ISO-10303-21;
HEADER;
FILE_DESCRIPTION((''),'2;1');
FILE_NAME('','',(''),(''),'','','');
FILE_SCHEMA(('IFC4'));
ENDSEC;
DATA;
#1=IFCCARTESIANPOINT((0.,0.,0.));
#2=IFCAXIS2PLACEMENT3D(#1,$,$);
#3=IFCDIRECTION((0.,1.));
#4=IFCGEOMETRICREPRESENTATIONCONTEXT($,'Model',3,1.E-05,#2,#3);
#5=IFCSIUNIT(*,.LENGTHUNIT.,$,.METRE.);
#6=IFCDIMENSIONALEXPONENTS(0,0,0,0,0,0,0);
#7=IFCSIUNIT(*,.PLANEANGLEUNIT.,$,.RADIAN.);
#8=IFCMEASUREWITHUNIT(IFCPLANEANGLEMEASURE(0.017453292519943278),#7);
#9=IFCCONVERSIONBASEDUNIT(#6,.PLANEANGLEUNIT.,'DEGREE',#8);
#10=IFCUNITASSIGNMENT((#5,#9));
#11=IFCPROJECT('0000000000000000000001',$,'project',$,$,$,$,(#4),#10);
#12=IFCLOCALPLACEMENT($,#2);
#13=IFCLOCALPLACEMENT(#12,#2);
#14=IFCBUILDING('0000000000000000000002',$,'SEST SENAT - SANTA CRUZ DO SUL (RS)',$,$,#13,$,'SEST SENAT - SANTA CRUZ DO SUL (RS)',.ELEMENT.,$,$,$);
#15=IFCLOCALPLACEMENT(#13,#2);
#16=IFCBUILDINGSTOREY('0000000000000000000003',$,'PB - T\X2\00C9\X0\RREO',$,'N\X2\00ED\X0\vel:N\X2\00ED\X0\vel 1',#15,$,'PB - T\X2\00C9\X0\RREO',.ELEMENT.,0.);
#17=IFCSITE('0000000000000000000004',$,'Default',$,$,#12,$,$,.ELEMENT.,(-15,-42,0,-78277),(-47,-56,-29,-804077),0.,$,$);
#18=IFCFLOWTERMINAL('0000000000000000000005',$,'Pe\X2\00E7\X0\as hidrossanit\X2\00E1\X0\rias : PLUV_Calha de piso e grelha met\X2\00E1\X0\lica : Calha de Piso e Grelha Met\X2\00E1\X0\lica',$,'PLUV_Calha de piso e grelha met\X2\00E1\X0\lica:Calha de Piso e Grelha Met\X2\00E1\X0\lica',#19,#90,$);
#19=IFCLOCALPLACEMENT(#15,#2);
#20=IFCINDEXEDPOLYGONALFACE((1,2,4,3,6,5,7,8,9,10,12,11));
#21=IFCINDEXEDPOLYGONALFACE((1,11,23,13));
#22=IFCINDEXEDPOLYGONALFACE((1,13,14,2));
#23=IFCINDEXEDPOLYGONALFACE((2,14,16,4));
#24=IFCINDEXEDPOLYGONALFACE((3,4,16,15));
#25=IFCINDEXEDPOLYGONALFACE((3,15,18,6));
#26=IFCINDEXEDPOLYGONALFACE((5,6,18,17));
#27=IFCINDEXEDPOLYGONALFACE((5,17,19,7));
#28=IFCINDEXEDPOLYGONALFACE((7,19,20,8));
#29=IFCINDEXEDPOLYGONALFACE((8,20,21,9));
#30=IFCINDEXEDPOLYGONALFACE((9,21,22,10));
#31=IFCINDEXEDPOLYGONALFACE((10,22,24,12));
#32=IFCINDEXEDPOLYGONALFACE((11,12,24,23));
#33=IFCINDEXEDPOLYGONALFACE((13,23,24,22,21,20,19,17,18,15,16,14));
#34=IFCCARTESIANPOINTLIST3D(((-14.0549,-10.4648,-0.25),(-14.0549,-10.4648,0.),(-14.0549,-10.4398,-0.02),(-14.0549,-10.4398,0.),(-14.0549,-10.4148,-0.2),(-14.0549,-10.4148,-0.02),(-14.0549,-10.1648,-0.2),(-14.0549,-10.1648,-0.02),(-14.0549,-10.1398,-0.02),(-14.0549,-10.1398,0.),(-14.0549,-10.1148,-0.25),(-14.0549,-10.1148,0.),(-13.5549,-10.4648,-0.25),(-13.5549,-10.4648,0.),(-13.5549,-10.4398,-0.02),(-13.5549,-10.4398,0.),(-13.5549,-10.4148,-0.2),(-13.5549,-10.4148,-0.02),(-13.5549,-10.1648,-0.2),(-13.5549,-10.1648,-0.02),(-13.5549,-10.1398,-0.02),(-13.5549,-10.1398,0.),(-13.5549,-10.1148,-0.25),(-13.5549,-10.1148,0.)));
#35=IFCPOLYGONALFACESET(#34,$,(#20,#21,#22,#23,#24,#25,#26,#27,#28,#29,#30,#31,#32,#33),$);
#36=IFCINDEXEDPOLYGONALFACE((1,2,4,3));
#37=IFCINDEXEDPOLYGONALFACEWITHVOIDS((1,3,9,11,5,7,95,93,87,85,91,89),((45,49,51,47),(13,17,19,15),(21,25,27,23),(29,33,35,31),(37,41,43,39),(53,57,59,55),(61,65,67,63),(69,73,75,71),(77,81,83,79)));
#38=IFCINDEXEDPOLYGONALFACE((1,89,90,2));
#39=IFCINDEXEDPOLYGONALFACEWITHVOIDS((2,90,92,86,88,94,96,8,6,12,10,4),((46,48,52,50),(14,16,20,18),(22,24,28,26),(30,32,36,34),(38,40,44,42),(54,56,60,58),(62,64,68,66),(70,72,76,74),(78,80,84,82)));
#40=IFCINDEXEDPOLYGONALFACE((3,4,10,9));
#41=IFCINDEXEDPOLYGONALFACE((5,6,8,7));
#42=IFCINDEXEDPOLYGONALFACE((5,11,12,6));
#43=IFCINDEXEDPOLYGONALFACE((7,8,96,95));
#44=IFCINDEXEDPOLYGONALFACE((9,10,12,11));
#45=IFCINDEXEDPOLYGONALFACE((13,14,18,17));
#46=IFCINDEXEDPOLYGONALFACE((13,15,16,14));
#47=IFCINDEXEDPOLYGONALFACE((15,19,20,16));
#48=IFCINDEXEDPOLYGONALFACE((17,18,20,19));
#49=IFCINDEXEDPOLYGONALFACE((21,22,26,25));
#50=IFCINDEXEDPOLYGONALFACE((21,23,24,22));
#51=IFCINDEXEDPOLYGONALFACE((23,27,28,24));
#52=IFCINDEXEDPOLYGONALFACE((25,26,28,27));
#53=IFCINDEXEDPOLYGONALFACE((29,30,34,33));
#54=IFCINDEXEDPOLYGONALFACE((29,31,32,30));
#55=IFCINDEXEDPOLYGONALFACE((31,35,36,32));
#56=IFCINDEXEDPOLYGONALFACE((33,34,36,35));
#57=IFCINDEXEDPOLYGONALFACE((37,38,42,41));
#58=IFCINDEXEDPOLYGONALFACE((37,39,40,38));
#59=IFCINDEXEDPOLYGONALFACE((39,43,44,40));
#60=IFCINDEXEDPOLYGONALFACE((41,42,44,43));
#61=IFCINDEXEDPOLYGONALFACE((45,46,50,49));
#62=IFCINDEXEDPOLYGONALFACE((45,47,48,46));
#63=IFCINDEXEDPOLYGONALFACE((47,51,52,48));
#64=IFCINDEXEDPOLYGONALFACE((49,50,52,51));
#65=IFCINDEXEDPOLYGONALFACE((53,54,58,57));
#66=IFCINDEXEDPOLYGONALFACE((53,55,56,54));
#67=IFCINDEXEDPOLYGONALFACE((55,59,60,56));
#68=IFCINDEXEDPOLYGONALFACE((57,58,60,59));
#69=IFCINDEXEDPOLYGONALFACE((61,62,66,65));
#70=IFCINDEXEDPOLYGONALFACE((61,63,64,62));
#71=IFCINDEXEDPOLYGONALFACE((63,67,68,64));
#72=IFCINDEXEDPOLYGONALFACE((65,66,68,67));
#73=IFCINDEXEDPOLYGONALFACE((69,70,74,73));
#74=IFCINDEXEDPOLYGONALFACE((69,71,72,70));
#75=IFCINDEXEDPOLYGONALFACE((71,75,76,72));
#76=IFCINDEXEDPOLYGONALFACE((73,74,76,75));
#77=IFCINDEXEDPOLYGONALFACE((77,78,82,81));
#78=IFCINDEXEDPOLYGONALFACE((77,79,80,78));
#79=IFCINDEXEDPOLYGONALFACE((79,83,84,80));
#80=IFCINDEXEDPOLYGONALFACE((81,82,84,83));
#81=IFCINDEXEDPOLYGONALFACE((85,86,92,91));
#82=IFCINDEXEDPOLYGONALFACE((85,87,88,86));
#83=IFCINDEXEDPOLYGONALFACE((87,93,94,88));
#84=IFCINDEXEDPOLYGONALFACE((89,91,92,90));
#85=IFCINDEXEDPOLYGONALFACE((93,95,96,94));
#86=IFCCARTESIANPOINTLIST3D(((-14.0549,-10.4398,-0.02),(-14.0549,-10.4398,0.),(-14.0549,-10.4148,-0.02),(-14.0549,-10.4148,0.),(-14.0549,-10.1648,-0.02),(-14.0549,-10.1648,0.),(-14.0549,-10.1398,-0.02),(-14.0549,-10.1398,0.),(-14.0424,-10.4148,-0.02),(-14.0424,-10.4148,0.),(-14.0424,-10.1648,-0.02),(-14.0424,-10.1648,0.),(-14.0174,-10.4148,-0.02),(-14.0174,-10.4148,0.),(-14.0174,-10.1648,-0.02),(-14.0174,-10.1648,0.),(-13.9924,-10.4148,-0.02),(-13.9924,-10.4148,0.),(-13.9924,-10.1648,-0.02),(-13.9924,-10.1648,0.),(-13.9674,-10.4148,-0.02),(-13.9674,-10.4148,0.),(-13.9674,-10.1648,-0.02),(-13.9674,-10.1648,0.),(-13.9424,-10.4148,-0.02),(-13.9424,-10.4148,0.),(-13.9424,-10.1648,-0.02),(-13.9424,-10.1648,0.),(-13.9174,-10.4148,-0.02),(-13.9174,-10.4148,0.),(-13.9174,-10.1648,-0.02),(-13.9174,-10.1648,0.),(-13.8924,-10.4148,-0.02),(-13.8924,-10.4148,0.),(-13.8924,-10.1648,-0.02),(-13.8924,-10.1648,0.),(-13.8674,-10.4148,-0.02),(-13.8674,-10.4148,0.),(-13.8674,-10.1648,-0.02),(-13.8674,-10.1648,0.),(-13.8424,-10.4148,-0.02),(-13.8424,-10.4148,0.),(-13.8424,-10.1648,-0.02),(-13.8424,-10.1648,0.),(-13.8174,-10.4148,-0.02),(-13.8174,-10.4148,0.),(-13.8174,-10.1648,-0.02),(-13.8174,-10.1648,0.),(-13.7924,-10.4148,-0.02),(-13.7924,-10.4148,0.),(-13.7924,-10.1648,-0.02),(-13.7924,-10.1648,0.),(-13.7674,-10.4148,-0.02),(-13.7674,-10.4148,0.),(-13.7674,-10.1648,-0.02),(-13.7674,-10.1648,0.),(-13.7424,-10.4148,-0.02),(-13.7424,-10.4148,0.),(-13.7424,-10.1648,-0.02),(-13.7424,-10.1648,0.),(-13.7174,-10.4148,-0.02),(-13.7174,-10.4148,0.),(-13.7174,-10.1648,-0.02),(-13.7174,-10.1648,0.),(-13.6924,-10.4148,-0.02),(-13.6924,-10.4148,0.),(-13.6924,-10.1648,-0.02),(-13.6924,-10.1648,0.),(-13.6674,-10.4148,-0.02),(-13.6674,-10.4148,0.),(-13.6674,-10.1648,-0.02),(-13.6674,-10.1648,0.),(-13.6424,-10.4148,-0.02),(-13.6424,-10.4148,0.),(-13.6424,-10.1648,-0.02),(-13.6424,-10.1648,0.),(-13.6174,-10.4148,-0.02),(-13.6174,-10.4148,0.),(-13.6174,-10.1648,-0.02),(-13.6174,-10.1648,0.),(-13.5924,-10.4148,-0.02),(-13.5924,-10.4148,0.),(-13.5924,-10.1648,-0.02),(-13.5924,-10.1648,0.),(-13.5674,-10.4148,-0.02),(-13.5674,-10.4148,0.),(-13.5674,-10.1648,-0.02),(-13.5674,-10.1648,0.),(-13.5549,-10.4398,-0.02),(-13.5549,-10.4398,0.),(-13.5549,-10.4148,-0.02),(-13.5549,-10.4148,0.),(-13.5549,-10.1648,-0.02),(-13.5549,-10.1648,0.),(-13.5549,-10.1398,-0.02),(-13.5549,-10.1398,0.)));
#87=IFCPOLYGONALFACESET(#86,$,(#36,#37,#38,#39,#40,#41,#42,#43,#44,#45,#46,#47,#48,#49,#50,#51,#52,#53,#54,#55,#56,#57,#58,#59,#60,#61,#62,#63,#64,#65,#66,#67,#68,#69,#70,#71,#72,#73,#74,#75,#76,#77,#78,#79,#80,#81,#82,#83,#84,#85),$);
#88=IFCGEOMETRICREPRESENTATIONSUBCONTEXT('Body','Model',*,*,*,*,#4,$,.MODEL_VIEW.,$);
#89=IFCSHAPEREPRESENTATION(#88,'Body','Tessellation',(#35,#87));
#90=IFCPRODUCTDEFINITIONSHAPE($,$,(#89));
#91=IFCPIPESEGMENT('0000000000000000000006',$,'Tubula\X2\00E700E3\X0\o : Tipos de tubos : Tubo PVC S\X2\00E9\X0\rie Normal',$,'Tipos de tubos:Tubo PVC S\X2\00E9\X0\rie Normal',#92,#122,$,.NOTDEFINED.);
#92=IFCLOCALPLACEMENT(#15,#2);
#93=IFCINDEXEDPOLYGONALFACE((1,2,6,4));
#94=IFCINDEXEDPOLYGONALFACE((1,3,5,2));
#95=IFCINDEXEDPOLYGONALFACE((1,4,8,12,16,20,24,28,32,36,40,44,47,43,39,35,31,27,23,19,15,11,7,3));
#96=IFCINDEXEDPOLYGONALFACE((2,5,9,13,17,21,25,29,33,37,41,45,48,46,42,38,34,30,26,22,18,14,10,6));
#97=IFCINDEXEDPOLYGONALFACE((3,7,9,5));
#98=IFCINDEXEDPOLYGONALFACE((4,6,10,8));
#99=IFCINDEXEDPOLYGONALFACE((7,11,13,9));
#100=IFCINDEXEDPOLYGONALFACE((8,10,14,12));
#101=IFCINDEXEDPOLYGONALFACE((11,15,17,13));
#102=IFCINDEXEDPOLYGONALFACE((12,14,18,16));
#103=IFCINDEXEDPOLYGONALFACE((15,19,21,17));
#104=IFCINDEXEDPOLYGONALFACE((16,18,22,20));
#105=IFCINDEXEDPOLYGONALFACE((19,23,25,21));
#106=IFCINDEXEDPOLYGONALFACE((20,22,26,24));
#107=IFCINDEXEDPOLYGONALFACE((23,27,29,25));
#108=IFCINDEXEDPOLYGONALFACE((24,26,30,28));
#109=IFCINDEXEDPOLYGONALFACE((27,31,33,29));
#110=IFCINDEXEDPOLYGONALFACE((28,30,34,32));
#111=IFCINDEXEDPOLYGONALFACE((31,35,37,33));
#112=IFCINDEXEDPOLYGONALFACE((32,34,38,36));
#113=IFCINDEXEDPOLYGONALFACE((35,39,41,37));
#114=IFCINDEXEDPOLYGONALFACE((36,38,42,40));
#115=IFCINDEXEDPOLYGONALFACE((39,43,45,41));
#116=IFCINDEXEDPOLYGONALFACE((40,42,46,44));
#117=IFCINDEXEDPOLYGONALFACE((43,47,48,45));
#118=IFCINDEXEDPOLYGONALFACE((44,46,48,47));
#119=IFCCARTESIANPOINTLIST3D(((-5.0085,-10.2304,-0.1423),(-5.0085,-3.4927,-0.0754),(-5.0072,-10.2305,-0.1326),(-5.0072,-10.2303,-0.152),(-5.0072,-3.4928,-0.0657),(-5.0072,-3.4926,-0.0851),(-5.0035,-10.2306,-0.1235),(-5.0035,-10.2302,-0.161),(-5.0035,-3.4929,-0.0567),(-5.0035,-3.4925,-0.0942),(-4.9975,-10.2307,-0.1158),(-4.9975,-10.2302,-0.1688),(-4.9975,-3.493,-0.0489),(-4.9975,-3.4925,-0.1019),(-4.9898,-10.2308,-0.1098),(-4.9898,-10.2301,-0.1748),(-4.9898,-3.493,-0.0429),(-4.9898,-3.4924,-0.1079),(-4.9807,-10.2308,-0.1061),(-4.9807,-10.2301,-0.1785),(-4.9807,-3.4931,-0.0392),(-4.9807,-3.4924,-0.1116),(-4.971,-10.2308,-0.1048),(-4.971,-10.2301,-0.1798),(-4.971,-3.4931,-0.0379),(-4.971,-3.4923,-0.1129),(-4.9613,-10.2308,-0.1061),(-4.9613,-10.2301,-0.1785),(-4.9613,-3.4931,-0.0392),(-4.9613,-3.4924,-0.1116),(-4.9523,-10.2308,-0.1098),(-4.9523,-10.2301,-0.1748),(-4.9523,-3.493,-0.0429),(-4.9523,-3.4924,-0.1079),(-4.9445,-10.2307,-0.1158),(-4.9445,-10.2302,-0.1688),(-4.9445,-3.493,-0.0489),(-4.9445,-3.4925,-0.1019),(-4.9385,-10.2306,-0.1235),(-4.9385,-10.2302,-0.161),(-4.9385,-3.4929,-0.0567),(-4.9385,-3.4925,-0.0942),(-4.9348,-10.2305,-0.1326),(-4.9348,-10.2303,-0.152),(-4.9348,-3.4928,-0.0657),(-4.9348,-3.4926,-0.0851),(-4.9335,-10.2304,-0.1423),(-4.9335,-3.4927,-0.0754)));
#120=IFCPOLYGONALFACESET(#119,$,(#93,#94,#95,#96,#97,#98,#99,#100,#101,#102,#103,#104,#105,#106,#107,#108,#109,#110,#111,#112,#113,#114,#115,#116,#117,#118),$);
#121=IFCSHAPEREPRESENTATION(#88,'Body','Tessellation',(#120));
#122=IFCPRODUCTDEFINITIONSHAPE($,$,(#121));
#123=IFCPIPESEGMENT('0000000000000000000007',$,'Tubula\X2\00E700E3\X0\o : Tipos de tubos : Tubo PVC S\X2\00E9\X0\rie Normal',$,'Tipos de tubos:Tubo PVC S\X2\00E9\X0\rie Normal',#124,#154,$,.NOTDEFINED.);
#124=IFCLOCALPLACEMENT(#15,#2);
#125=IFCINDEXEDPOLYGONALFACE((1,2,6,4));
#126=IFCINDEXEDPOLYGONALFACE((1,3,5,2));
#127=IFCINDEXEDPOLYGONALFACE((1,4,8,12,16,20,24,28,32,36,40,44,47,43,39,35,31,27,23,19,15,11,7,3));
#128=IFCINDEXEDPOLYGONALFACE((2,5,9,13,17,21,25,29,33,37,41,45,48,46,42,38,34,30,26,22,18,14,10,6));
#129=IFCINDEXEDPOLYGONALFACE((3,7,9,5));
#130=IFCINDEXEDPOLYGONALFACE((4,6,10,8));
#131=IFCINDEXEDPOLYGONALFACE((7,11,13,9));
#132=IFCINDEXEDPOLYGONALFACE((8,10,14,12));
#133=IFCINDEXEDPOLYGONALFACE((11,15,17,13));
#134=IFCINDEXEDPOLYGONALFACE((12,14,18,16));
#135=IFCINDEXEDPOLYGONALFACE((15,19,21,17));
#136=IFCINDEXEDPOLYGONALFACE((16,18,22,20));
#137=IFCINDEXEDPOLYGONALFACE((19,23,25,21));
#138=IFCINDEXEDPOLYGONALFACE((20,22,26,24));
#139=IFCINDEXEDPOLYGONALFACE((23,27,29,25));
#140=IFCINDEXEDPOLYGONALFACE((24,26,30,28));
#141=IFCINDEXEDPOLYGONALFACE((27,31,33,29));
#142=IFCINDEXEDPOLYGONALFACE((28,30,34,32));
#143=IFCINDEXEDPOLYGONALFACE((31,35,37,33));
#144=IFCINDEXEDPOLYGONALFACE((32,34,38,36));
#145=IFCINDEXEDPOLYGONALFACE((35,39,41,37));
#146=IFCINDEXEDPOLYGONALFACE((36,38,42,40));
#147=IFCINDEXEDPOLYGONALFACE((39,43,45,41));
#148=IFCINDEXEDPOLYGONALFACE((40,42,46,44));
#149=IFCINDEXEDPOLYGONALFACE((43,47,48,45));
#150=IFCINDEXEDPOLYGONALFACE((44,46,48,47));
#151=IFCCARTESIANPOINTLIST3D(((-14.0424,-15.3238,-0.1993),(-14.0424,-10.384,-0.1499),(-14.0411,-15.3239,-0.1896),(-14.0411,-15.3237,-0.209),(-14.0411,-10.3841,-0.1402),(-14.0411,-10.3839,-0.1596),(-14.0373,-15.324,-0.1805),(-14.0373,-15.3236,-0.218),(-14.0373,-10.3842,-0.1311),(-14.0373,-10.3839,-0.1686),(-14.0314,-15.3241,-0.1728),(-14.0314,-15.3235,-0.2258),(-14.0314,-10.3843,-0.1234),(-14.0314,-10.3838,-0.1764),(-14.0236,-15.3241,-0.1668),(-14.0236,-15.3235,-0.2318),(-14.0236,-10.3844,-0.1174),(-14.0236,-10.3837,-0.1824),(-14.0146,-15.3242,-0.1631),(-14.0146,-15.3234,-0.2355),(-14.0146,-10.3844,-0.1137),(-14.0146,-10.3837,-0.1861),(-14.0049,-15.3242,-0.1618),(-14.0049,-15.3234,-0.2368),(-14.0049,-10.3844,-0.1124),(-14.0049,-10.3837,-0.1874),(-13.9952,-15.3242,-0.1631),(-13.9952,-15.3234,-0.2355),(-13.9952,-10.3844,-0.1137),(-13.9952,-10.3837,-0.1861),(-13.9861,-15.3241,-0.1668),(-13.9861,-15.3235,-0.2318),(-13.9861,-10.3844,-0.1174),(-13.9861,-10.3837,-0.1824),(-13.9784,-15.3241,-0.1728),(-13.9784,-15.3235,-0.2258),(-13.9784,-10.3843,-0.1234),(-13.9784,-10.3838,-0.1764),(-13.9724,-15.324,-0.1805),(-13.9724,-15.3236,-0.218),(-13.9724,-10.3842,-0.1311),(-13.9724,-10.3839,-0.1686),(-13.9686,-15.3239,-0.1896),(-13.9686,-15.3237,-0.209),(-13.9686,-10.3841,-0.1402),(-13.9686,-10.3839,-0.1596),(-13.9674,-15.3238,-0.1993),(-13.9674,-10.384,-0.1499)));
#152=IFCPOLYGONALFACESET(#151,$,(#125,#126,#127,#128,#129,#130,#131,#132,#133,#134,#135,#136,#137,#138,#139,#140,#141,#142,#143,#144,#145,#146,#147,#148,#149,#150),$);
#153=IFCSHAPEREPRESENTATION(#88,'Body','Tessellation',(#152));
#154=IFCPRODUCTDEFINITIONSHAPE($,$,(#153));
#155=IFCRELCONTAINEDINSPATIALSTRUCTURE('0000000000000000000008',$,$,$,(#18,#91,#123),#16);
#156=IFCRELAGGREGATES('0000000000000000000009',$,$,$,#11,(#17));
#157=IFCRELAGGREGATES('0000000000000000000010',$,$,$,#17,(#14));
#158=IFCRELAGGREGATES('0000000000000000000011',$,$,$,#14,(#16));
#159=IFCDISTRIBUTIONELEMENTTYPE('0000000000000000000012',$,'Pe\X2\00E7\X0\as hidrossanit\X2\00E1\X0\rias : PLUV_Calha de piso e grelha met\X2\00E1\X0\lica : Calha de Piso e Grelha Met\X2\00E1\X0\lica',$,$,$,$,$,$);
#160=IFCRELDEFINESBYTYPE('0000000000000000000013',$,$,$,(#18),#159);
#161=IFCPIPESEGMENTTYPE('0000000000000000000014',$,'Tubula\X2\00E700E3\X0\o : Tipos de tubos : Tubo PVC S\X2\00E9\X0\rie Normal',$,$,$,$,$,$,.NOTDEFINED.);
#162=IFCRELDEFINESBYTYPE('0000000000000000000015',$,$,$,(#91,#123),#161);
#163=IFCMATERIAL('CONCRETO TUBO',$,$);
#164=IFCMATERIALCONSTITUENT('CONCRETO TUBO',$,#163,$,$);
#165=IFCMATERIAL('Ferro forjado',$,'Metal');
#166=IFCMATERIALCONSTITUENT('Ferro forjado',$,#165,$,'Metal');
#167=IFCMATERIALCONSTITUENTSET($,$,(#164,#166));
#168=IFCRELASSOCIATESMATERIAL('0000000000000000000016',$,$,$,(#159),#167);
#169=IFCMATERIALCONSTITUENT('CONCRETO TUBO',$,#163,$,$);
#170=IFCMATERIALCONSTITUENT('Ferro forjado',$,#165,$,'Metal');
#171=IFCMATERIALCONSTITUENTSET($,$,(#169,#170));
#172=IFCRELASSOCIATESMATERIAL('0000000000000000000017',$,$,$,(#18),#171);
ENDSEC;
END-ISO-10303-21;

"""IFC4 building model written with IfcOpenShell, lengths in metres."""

from ifc_helpers import new_model, entity, si_unit, converted_unit, direction, frame, origin, place, context, subcontext, project, spatial, arc, indexed_curve, outline, extrude, source, transform, mapped, material, constituent, constituent_set, type_object, type_shapes, element, save


model = new_model("IFC4")

# Units and contexts
model_context = context("Model", 3, precision=1e-05, world=origin(), true_north=direction((0.0, 1.0)))
body_context = subcontext(model_context, "Body", "Model", "MODEL_VIEW")
ifc_project = project(units=[si_unit("LENGTHUNIT", "METRE"), converted_unit("PLANEANGLEUNIT", "DEGREE", entity("IfcPlaneAngleMeasure", 0.017453292519943278), si_unit("PLANEANGLEUNIT", "RADIAN"), dimensions=[0, 0, 0, 0, 0, 0, 0])], contexts=[model_context])

# Site, building, storey
site_placement = place(None, origin())
site = spatial("IfcSite", under=ifc_project, at=site_placement, Name="Default", CompositionType="ELEMENT", RefLatitude=(-15, -42, 0, -78277), RefLongitude=(-47, -56, -29, -804077), RefElevation=0.0)
building_placement = place(site_placement, origin())
building = spatial("IfcBuilding", under=site, at=building_placement, Name="SEST SENAT - SANTA CRUZ DO SUL (RS)", LongName="SEST SENAT - SANTA CRUZ DO SUL (RS)", CompositionType="ELEMENT")
storey_placement = place(building_placement, origin())
storey = spatial("IfcBuildingStorey", under=building, at=storey_placement, Name="PB - TÉRREO", ObjectType="Nível:Nível 1", LongName="PB - TÉRREO", CompositionType="ELEMENT", Elevation=0.0)

# Flow terminal
ifc_material_1 = material(Name="CONCRETO TUBO")
ifc_material_2 = material(Name="Ferro forjado", Category="Metal")
ifc_constituent_1 = constituent(ifc_material_1, Name="CONCRETO TUBO")
ifc_constituent_2 = constituent(ifc_material_2, Name="Ferro forjado", Category="Metal")
ifc_constituent_set_1 = constituent_set(constituents=[ifc_constituent_1, ifc_constituent_2])
distribution_element_type = type_object("IfcDistributionElementType", Name="Peças hidrossanitárias : PLUV_Calha de piso e grelha metálica : Calha de Piso e Grelha Metálica", material=ifc_constituent_set_1)
shared_shape_1 = source(origin(), body_context, "Body", "SweptSolid", [
    extrude(outline(indexed_curve([(-0.175, -0.0817), (-0.15, -0.0817), (-0.15, -0.0617), (-0.125, -0.0617), (-0.125, 0.1183), (0.125, 0.1183), (0.125, -0.0617), (0.15, -0.0617), (0.15, -0.0817), (0.175, -0.0817), (0.175, 0.1683), (-0.175, 0.1683), (-0.175, -0.0817)], self_intersect=False)), frame((-0.25, 0.0, -0.0817), z_axis=(1.0, 0.0, 0.0), x_axis=(0.0, -1.0, 0.0)), (0.0, 0.0, 1.0), 0.5),
    extrude(outline(indexed_curve([(0.125, -0.25), (0.15, -0.25), (0.15, 0.25), (0.125, 0.25), (0.125, 0.2375), (-0.125, 0.2375), (-0.125, 0.25), (-0.15, 0.25), (-0.15, -0.25), (-0.125, -0.25), (-0.125, -0.2375), (0.125, -0.2375), (0.125, -0.25)], self_intersect=False), holes=[indexed_curve([(0.125, 0.2125), (0.125, 0.1875), (-0.125, 0.1875), (-0.125, 0.2125), (0.125, 0.2125)], self_intersect=False), indexed_curve([(0.125, 0.1625), (0.125, 0.1375), (-0.125, 0.1375), (-0.125, 0.1625), (0.125, 0.1625)], self_intersect=False), indexed_curve([(0.125, 0.1125), (0.125, 0.0875), (-0.125, 0.0875), (-0.125, 0.1125), (0.125, 0.1125)], self_intersect=False), indexed_curve([(0.125, 0.0625), (0.125, 0.0375), (-0.125, 0.0375), (-0.125, 0.0625), (0.125, 0.0625)], self_intersect=False), indexed_curve([(0.125, 0.0125), (0.125, -0.0125), (-0.125, -0.0125), (-0.125, 0.0125), (0.125, 0.0125)], self_intersect=False), indexed_curve([(0.125, -0.0375), (0.125, -0.0625), (-0.125, -0.0625), (-0.125, -0.0375), (0.125, -0.0375)], self_intersect=False), indexed_curve([(0.125, -0.0875), (0.125, -0.1125), (-0.125, -0.1125), (-0.125, -0.0875), (0.125, -0.0875)], self_intersect=False), indexed_curve([(0.125, -0.1375), (0.125, -0.1625), (-0.125, -0.1625), (-0.125, -0.1375), (0.125, -0.1375)], self_intersect=False), indexed_curve([(0.125, -0.1875), (0.125, -0.2125), (-0.125, -0.2125), (-0.125, -0.1875), (0.125, -0.1875)], self_intersect=False)]), frame((0.0, 0.0, -0.02), z_axis=(0.0, 0.0, 1.0), x_axis=(0.0, 1.0, 0.0)), (0.0, 0.0, 1.0), 0.02),
])
type_shapes(distribution_element_type, [shared_shape_1])
ifc_constituent_3 = constituent(ifc_material_1, Name="CONCRETO TUBO")
ifc_constituent_4 = constituent(ifc_material_2, Name="Ferro forjado", Category="Metal")
ifc_constituent_set_2 = constituent_set(constituents=[ifc_constituent_3, ifc_constituent_4])
flow_terminal_1_placement = place(storey_placement, frame((-13.8049, -10.2898, 0.0)))
element("IfcFlowTerminal", 1, at=flow_terminal_1_placement, inside=storey, type_object=distribution_element_type, material=ifc_constituent_set_2, Name="Peças hidrossanitárias : PLUV_Calha de piso e grelha metálica : Calha de Piso e Grelha Metálica", ObjectType="PLUV_Calha de piso e grelha metálica:Calha de Piso e Grelha Metálica", context=body_context, shape_type="MappedRepresentation", body=[
    mapped(shared_shape_1, transform((0.0, 0.0, 0.0), scale=1.0)),
])

# Pipe segments
pipe_segment_type_1 = type_object("IfcPipeSegmentType", Name="Tubulação : Tipos de tubos : Tubo PVC Série Normal", PredefinedType="NOTDEFINED")
pipe_segment_1_placement = place(storey_placement, frame((-5.0101, -10.2324, -0.1814)))
element("IfcPipeSegment", 2, at=pipe_segment_1_placement, inside=storey, type_object=pipe_segment_type_1, Name="Tubulação : Tipos de tubos : Tubo PVC Série Normal", ObjectType="Tipos de tubos:Tubo PVC Série Normal", PredefinedType="NOTDEFINED", context=body_context, shape_type="SweptSolid", body=[
    extrude(outline(indexed_curve([(0.0375, 0.0), (0.0265, 0.0265), (0.0, 0.0375), (-0.0265, 0.0265), (-0.0375, 0.0), (-0.0265, -0.0265), (0.0, -0.0375), (0.0265, -0.0265)], segments=[arc(1, 2, 3), arc(3, 4, 5), arc(5, 6, 7), arc(7, 8, 1)], self_intersect=False)), frame((0.0391, 0.002, 0.0391), z_axis=(0.0, 0.999951, 0.009925), x_axis=(1.0, 0.0, 0.0)), (0.0, 0.0, 1.0), 6.738),
])
pipe_segment_2_placement = place(storey_placement, frame((-14.044, -15.3258, -0.2384)))
element("IfcPipeSegment", 3, at=pipe_segment_2_placement, inside=storey, type_object=pipe_segment_type_1, Name="Tubulação : Tipos de tubos : Tubo PVC Série Normal", ObjectType="Tipos de tubos:Tubo PVC Série Normal", PredefinedType="NOTDEFINED", context=body_context, shape_type="SweptSolid", body=[
    extrude(outline(indexed_curve([(0.0375, 0.0), (0.0265, 0.0265), (0.0, 0.0375), (-0.0265, 0.0265), (-0.0375, 0.0), (-0.0265, -0.0265), (0.0, -0.0375), (0.0265, -0.0265)], segments=[arc(1, 2, 3), arc(3, 4, 5), arc(5, 6, 7), arc(7, 8, 1)], self_intersect=False)), frame((0.0391, 0.002, 0.0391), z_axis=(0.0, 0.99995, 0.01), x_axis=(-1.0, 0.0, 0.0)), (0.0, 0.0, 1.0), 4.94),
])

save(model, "model.ifc")
